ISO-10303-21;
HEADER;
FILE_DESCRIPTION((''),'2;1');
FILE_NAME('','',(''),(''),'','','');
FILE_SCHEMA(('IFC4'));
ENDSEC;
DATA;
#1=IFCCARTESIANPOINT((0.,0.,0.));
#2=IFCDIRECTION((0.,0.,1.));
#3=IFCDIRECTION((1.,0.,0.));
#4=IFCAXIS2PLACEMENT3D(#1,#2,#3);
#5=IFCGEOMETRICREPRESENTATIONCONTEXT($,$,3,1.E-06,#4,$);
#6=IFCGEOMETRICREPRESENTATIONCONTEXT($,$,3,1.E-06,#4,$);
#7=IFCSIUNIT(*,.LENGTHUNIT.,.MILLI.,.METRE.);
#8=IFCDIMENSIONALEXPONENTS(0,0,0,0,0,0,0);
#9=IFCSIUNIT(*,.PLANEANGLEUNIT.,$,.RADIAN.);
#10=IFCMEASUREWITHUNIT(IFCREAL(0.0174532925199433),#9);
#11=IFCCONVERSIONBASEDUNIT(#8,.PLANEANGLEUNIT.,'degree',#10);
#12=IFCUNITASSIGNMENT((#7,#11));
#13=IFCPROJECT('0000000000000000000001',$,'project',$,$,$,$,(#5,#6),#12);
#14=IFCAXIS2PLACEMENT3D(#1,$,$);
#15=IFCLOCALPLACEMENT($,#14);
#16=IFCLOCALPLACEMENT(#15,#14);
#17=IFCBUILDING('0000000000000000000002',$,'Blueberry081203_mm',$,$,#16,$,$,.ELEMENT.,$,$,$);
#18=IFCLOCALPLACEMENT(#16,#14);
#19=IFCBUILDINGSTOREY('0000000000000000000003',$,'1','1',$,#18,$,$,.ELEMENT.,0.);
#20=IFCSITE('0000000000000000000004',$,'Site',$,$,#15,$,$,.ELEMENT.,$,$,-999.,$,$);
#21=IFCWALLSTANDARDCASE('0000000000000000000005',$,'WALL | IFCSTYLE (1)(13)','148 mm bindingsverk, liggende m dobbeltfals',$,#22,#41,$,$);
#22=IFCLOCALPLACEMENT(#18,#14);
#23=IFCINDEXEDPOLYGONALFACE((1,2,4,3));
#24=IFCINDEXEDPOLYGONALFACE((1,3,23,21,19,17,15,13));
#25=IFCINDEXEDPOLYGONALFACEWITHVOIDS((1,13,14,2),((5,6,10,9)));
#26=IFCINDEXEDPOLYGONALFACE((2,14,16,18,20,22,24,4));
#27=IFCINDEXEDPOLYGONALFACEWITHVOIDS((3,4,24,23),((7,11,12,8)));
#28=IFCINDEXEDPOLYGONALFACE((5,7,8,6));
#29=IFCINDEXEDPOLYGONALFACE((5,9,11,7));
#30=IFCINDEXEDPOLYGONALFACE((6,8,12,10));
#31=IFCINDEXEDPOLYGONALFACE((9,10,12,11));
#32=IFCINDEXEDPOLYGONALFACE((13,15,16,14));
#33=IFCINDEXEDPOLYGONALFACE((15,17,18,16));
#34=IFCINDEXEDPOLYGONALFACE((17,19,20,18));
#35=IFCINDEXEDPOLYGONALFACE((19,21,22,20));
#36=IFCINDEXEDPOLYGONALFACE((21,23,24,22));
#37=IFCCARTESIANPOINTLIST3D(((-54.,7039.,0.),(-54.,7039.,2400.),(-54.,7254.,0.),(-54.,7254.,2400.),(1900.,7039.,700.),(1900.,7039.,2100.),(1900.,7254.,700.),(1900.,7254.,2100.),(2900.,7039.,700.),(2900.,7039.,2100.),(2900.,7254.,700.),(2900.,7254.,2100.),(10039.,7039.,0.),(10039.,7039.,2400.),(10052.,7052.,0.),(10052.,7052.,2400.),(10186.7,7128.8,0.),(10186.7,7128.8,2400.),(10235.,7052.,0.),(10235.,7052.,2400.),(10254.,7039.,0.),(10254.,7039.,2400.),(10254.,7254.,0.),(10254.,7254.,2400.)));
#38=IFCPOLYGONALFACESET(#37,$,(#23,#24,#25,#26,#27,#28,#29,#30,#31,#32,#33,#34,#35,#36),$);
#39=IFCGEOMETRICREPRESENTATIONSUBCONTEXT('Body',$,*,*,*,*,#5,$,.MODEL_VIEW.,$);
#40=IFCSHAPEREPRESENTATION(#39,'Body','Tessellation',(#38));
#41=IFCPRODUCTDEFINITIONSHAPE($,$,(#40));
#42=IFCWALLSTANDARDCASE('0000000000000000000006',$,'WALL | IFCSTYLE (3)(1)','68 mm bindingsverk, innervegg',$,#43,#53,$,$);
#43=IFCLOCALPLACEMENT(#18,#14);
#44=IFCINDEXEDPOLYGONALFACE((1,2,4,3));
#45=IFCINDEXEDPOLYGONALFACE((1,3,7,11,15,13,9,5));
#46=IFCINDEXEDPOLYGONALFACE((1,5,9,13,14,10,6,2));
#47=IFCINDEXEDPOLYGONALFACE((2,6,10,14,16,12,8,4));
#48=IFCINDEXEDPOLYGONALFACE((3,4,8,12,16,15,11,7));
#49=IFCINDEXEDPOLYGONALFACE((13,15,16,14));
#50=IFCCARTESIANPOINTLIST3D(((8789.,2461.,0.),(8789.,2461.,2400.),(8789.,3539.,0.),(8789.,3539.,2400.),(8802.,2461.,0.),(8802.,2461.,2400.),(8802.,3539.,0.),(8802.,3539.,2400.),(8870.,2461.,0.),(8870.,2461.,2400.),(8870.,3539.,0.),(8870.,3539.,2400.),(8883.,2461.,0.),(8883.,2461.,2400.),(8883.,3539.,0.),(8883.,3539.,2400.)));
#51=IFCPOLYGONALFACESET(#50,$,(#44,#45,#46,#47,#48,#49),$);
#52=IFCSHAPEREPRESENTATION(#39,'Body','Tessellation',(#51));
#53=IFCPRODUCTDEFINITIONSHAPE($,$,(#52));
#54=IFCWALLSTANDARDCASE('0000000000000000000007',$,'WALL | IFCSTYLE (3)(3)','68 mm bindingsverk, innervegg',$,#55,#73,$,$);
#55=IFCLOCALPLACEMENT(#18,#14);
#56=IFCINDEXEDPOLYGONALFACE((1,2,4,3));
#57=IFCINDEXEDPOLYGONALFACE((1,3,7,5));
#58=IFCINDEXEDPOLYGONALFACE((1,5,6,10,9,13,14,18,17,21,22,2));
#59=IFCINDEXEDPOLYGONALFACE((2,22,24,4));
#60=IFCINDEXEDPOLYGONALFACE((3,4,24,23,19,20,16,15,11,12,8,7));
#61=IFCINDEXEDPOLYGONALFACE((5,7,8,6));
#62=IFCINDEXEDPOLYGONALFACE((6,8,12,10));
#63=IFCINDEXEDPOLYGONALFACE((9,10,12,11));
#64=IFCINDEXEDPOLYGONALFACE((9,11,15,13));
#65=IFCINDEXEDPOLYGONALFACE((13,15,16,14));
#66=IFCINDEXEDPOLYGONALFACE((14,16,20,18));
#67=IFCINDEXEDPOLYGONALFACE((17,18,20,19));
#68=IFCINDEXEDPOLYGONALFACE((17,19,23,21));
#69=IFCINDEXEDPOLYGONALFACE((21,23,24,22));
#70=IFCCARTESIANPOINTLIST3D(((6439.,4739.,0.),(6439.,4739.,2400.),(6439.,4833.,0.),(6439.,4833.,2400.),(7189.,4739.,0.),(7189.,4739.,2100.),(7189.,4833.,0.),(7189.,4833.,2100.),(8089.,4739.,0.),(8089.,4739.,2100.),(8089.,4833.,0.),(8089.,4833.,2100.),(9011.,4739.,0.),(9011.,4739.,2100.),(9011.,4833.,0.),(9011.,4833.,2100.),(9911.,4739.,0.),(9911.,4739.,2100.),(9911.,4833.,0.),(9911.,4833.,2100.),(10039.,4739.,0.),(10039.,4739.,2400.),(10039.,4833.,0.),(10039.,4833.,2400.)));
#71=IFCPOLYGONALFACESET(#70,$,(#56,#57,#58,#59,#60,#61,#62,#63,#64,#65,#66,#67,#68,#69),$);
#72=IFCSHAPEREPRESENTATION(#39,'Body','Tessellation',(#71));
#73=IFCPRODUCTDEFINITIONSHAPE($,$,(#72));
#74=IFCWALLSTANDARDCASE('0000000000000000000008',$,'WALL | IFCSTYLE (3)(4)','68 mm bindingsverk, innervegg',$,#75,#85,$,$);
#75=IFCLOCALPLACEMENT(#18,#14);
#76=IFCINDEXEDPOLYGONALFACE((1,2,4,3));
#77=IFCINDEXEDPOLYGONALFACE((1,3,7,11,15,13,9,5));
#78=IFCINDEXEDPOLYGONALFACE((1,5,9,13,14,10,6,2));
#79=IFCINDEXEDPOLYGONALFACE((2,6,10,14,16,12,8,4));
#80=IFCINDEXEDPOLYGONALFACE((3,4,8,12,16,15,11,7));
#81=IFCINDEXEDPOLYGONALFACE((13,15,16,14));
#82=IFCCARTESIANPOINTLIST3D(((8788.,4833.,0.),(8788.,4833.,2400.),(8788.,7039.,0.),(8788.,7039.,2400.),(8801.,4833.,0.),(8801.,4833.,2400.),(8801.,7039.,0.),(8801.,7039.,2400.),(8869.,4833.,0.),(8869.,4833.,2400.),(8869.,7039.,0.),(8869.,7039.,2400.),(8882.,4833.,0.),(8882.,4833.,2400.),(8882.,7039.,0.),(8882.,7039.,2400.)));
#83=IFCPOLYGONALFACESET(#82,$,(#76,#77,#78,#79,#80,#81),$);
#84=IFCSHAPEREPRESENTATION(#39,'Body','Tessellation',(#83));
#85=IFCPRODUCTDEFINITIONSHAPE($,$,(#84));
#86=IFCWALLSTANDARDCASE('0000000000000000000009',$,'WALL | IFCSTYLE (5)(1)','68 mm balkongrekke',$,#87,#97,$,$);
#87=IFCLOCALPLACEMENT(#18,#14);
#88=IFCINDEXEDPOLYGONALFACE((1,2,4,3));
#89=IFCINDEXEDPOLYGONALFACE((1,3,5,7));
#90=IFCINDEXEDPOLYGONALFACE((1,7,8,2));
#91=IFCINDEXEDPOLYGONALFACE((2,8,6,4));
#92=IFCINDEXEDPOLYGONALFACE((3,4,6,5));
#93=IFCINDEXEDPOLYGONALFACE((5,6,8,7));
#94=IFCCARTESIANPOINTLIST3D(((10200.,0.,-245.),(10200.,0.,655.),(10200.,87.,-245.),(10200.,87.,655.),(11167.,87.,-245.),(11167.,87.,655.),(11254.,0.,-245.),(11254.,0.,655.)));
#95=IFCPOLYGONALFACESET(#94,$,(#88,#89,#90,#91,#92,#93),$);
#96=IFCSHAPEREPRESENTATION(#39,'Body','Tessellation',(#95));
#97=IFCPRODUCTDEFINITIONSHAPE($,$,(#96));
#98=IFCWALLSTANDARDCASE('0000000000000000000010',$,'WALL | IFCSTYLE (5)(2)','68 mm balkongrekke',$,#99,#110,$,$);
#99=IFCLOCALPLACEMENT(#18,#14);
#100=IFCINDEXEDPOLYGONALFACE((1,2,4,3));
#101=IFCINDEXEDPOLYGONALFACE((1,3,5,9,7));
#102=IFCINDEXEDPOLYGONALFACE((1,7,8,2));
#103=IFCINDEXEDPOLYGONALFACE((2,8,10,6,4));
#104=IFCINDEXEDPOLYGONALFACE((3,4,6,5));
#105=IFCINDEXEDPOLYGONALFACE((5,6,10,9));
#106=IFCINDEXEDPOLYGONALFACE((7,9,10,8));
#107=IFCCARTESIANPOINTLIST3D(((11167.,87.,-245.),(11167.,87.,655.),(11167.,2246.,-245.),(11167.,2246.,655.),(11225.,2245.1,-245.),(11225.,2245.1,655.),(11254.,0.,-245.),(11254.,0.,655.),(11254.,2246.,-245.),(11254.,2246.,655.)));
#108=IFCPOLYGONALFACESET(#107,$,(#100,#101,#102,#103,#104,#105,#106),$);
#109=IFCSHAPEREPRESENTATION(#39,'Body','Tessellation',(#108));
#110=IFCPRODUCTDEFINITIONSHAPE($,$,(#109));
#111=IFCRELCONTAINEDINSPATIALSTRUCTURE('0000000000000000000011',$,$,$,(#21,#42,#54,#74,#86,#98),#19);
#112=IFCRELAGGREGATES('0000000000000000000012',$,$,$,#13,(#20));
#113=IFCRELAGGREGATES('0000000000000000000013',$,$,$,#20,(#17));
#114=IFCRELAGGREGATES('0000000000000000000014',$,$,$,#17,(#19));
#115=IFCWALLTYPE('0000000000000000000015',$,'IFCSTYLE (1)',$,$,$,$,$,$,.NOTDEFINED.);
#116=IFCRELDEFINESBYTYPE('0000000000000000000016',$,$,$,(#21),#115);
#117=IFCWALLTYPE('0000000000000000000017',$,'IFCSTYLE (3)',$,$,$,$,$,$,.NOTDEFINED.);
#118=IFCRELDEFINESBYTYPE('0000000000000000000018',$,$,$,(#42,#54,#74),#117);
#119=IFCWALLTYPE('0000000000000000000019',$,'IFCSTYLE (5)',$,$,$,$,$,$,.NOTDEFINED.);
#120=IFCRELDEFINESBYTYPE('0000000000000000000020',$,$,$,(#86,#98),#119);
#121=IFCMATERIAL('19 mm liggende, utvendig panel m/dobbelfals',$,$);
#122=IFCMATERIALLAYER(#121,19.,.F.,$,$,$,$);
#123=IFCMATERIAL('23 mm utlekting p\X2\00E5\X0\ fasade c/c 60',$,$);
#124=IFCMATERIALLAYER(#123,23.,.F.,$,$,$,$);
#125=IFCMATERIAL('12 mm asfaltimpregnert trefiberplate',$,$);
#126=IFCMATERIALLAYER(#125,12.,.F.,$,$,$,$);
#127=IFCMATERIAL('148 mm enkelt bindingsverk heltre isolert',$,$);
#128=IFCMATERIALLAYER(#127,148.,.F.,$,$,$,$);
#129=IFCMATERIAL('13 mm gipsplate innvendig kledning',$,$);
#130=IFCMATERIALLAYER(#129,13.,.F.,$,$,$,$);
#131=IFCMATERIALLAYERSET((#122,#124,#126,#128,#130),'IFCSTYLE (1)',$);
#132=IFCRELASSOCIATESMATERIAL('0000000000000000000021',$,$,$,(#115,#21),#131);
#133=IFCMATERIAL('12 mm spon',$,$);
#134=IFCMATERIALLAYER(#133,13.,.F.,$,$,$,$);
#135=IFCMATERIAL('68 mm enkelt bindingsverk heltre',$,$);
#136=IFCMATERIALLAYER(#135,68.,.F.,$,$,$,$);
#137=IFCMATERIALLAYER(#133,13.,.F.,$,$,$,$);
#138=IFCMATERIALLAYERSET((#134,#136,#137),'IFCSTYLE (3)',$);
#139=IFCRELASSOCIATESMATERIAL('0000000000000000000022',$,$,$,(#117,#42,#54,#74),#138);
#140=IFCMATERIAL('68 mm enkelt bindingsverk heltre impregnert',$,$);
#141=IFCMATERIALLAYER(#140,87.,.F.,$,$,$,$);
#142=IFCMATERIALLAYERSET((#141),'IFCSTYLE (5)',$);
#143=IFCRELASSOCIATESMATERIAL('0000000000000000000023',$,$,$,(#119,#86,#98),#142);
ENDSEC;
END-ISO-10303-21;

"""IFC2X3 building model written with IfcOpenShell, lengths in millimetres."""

from ifc_helpers import new_model, entity, si_unit, converted_unit, frame, origin, origin_with_axes, origin_2d_with_axis, place, context, subcontext, project, spatial, polyline, segment, composite_curve, rectangle, outline, extrude, material, layer, layer_set, layer_usage, type_object, element, save


model = new_model("IFC2X3")

# Units and contexts
context_of_model_1 = context(None, 3, precision=1e-06, world=origin_with_axes())
context_of_model_2 = context(None, 3, precision=1e-06, world=origin_with_axes())
body_context = subcontext(context_of_model_1, "Body", None, "MODEL_VIEW")
ifc_project = project(units=[si_unit("LENGTHUNIT", "METRE", prefix="MILLI"), converted_unit("PLANEANGLEUNIT", "degree", entity("IfcReal", 0.0174532925199433), si_unit("PLANEANGLEUNIT", "RADIAN"), dimensions=[0, 0, 0, 0, 0, 0, 0])], contexts=[context_of_model_1, context_of_model_2])

# Site, building, storey
site_placement = place(None, origin())
site = spatial("IfcSite", under=ifc_project, at=site_placement, Name="Site", CompositionType="ELEMENT", RefElevation=-999.0)
building_placement = place(site_placement, origin())
building = spatial("IfcBuilding", under=site, at=building_placement, Name="Blueberry081203_mm", CompositionType="ELEMENT")
storey_placement = place(building_placement, origin())
storey = spatial("IfcBuildingStorey", under=building, at=storey_placement, Name="1", Description="1", CompositionType="ELEMENT", Elevation=0.0)

# Shared definitions
ifc_material_1 = material(Name="19 mm liggende, utvendig panel m/dobbelfals")
ifc_layer_1 = layer(ifc_material_1, 19.0, ventilated=False)
ifc_material_2 = material(Name="23 mm utlekting på fasade c/c 60")
ifc_layer_2 = layer(ifc_material_2, 23.0, ventilated=False)
ifc_material_3 = material(Name="12 mm asfaltimpregnert trefiberplate")
ifc_layer_3 = layer(ifc_material_3, 12.0, ventilated=False)
ifc_material_4 = material(Name="148 mm enkelt bindingsverk heltre isolert")
ifc_layer_4 = layer(ifc_material_4, 148.0, ventilated=False)
ifc_material_5 = material(Name="13 mm gipsplate innvendig kledning")
ifc_layer_5 = layer(ifc_material_5, 13.0, ventilated=False)
ifc_layer_set_1 = layer_set([ifc_layer_1, ifc_layer_2, ifc_layer_3, ifc_layer_4, ifc_layer_5], Name="IFCSTYLE (1)")
wall_type_1 = type_object("IfcWallType", Name="IFCSTYLE (1)", PredefinedType="NOTDEFINED", material=ifc_layer_set_1)

# Wall, opening
ifc_layer_usage_1 = layer_usage(ifc_layer_set_1, "AXIS2", "POSITIVE", 0.0)
wall_1_placement = place(storey_placement, frame((10254.0, 7254.0, 0.0), z_axis=(0.0, 0.0, 1.0), x_axis=(-1.0, 0.0, 0.0)))
wall_1 = element("IfcWallStandardCase", 1, at=wall_1_placement, inside=storey, type_object=wall_type_1, material=ifc_layer_usage_1, Name="WALL | IFCSTYLE (1)(13)", Description="148 mm bindingsverk, liggende m dobbeltfals", context=body_context, shape_type="SweptSolid", held_by="IfcProductRepresentation", body=[
    extrude(outline(composite_curve([segment(polyline([(0.0, 19.0), (0.0, 0.0)]), True, "CONTINUOUS"), segment(polyline([(0.0, 0.0), (0.0, 0.0)]), True, "CONTINUOUS"), segment(polyline([(0.0, 0.0), (10308.0, 0.0)]), True, "CONTINUOUS"), segment(polyline([(10308.0, 0.0), (10308.0, 19.0)]), True, "CONTINUOUS"), segment(polyline([(10308.0, 19.0), (10308.0, 42.0)]), True, "CONTINUOUS"), segment(polyline([(10308.0, 42.0), (10308.0, 54.0)]), True, "CONTINUOUS"), segment(polyline([(10308.0, 54.0), (10308.0, 202.0)]), True, "CONTINUOUS"), segment(polyline([(10308.0, 202.0), (10308.0, 215.0)]), True, "CONTINUOUS"), segment(polyline([(10308.0, 215.0), (215.0, 215.0)]), True, "CONTINUOUS"), segment(polyline([(215.0, 215.0), (202.0, 202.0)]), True, "CONTINUOUS"), segment(polyline([(202.0, 202.0), (67.3, 125.2)]), True, "CONTINUOUS"), segment(polyline([(67.3, 125.2), (19.0, 202.0)]), True, "CONTINUOUS"), segment(polyline([(19.0, 202.0), (0.0, 215.0)]), True, "CONTINUOUS"), segment(polyline([(0.0, 215.0), (0.0, 215.0)]), True, "CONTINUOUS"), segment(polyline([(0.0, 215.0), (0.0, 202.0)]), True, "CONTINUOUS"), segment(polyline([(0.0, 202.0), (0.0, 54.0)]), True, "CONTINUOUS"), segment(polyline([(0.0, 54.0), (0.0, 42.0)]), True, "CONTINUOUS"), segment(polyline([(0.0, 42.0), (0.0, 19.0)]), True, "CONTINUOUS")], self_intersect=False)), origin(), (0.0, 0.0, 1.0), 2400.0),
])
opening_1_placement = place(wall_1_placement, frame((7354.0, 107.5, 700.0)))
element("IfcOpeningElement", 2, at=opening_1_placement, cuts=wall_1, context=body_context, shape_type="SweptSolid", held_by="IfcProductRepresentation", body=[
    extrude(rectangle(XDim=1000.0, YDim=1400.0, at=origin_2d_with_axis()), frame((500.0, 107.5, 700.0), z_axis=(0.0, -1.0, 0.0), x_axis=(1.0, 0.0, 0.0)), (0.0, 0.0, 1.0), 215.0),
])

# Wall
ifc_material_6 = material(Name="12 mm spon")
ifc_layer_6 = layer(ifc_material_6, 13.0, ventilated=False)
ifc_material_7 = material(Name="68 mm enkelt bindingsverk heltre")
ifc_layer_7 = layer(ifc_material_7, 68.0, ventilated=False)
ifc_layer_8 = layer(ifc_material_6, 13.0, ventilated=False)
ifc_layer_set_2 = layer_set([ifc_layer_6, ifc_layer_7, ifc_layer_8], Name="IFCSTYLE (3)")
ifc_layer_usage_2 = layer_usage(ifc_layer_set_2, "AXIS2", "POSITIVE", 0.0)
wall_type_2 = type_object("IfcWallType", Name="IFCSTYLE (3)", PredefinedType="NOTDEFINED", material=ifc_layer_set_2)
wall_2_placement = place(storey_placement, frame((8883.0, 2461.0, 0.0), z_axis=(0.0, 0.0, 1.0), x_axis=(0.0, 1.0, 0.0)))
element("IfcWallStandardCase", 3, at=wall_2_placement, inside=storey, type_object=wall_type_2, material=ifc_layer_usage_2, Name="WALL | IFCSTYLE (3)(1)", Description="68 mm bindingsverk, innervegg", context=body_context, shape_type="SweptSolid", held_by="IfcProductRepresentation", body=[
    extrude(outline(composite_curve([segment(polyline([(0.0, 13.0), (0.0, 0.0)]), True, "CONTINUOUS"), segment(polyline([(0.0, 0.0), (1078.0, 0.0)]), True, "CONTINUOUS"), segment(polyline([(1078.0, 0.0), (1078.0, 13.0)]), True, "CONTINUOUS"), segment(polyline([(1078.0, 13.0), (1078.0, 81.0)]), True, "CONTINUOUS"), segment(polyline([(1078.0, 81.0), (1078.0, 94.0)]), True, "CONTINUOUS"), segment(polyline([(1078.0, 94.0), (0.0, 94.0)]), True, "CONTINUOUS"), segment(polyline([(0.0, 94.0), (0.0, 81.0)]), True, "CONTINUOUS"), segment(polyline([(0.0, 81.0), (0.0, 13.0)]), True, "CONTINUOUS")], self_intersect=False)), origin(), (0.0, 0.0, 1.0), 2400.0),
])

# Wall, openings
ifc_layer_usage_3 = layer_usage(ifc_layer_set_2, "AXIS2", "POSITIVE", 0.0)
wall_3_placement = place(storey_placement, frame((6439.0, 4739.0, 0.0)))
wall_3 = element("IfcWallStandardCase", 4, at=wall_3_placement, inside=storey, type_object=wall_type_2, material=ifc_layer_usage_3, Name="WALL | IFCSTYLE (3)(3)", Description="68 mm bindingsverk, innervegg", context=body_context, shape_type="SweptSolid", held_by="IfcProductRepresentation", body=[
    extrude(outline(composite_curve([segment(polyline([(0.0, 13.0), (0.0, 0.0)]), True, "CONTINUOUS"), segment(polyline([(0.0, 0.0), (3600.0, 0.0)]), True, "CONTINUOUS"), segment(polyline([(3600.0, 0.0), (3600.0, 13.0)]), True, "CONTINUOUS"), segment(polyline([(3600.0, 13.0), (3600.0, 81.0)]), True, "CONTINUOUS"), segment(polyline([(3600.0, 81.0), (3600.0, 94.0)]), True, "CONTINUOUS"), segment(polyline([(3600.0, 94.0), (0.0, 94.0)]), True, "CONTINUOUS"), segment(polyline([(0.0, 94.0), (0.0, 81.0)]), True, "CONTINUOUS"), segment(polyline([(0.0, 81.0), (0.0, 13.0)]), True, "CONTINUOUS")], self_intersect=False)), origin(), (0.0, 0.0, 1.0), 2400.0),
])
opening_2_placement = place(wall_3_placement, frame((2572.0, 47.0, 0.0)))
element("IfcOpeningElement", 5, at=opening_2_placement, cuts=wall_3, context=body_context, shape_type="SweptSolid", held_by="IfcProductRepresentation", body=[
    extrude(rectangle(XDim=900.0, YDim=2100.0, at=origin_2d_with_axis()), frame((450.0, 47.0, 1050.0), z_axis=(0.0, -1.0, 0.0), x_axis=(1.0, 0.0, 0.0)), (0.0, 0.0, 1.0), 94.0),
])
opening_3_placement = place(wall_3_placement, frame((750.0, 47.0, 0.0)))
element("IfcOpeningElement", 6, at=opening_3_placement, cuts=wall_3, context=body_context, shape_type="SweptSolid", held_by="IfcProductRepresentation", body=[
    extrude(rectangle(XDim=900.0, YDim=2100.0, at=origin_2d_with_axis()), frame((450.0, 47.0, 1050.0), z_axis=(0.0, -1.0, 0.0), x_axis=(1.0, 0.0, 0.0)), (0.0, 0.0, 1.0), 94.0),
])

# Walls
ifc_layer_usage_4 = layer_usage(ifc_layer_set_2, "AXIS2", "POSITIVE", 0.0)
wall_4_placement = place(storey_placement, frame((8882.0, 4833.0, 0.0), z_axis=(0.0, 0.0, 1.0), x_axis=(0.0, 1.0, 0.0)))
element("IfcWallStandardCase", 7, at=wall_4_placement, inside=storey, type_object=wall_type_2, material=ifc_layer_usage_4, Name="WALL | IFCSTYLE (3)(4)", Description="68 mm bindingsverk, innervegg", context=body_context, shape_type="SweptSolid", held_by="IfcProductRepresentation", body=[
    extrude(outline(composite_curve([segment(polyline([(0.0, 13.0), (0.0, 0.0)]), True, "CONTINUOUS"), segment(polyline([(0.0, 0.0), (2206.0, 0.0)]), True, "CONTINUOUS"), segment(polyline([(2206.0, 0.0), (2206.0, 13.0)]), True, "CONTINUOUS"), segment(polyline([(2206.0, 13.0), (2206.0, 81.0)]), True, "CONTINUOUS"), segment(polyline([(2206.0, 81.0), (2206.0, 94.0)]), True, "CONTINUOUS"), segment(polyline([(2206.0, 94.0), (0.0, 94.0)]), True, "CONTINUOUS"), segment(polyline([(0.0, 94.0), (0.0, 81.0)]), True, "CONTINUOUS"), segment(polyline([(0.0, 81.0), (0.0, 13.0)]), True, "CONTINUOUS")], self_intersect=False)), origin(), (0.0, 0.0, 1.0), 2400.0),
])
ifc_material_8 = material(Name="68 mm enkelt bindingsverk heltre impregnert")
ifc_layer_9 = layer(ifc_material_8, 87.0, ventilated=False)
ifc_layer_set_3 = layer_set([ifc_layer_9], Name="IFCSTYLE (5)")
ifc_layer_usage_5 = layer_usage(ifc_layer_set_3, "AXIS2", "POSITIVE", 0.0)
wall_type_3 = type_object("IfcWallType", Name="IFCSTYLE (5)", PredefinedType="NOTDEFINED", material=ifc_layer_set_3)
wall_5_placement = place(storey_placement, frame((10200.0, 0.0, -245.0)))
element("IfcWallStandardCase", 8, at=wall_5_placement, inside=storey, type_object=wall_type_3, material=ifc_layer_usage_5, Name="WALL | IFCSTYLE (5)(1)", Description="68 mm balkongrekke", context=body_context, shape_type="SweptSolid", held_by="IfcProductRepresentation", body=[
    extrude(outline(composite_curve([segment(polyline([(0.0, 87.0), (0.0, 0.0)]), True, "CONTINUOUS"), segment(polyline([(0.0, 0.0), (1054.0, 0.0)]), True, "CONTINUOUS"), segment(polyline([(1054.0, 0.0), (967.0, 87.0)]), True, "CONTINUOUS"), segment(polyline([(967.0, 87.0), (0.0, 87.0)]), True, "CONTINUOUS")], self_intersect=False)), origin(), (0.0, 0.0, 1.0), 900.0),
])
ifc_layer_usage_6 = layer_usage(ifc_layer_set_3, "AXIS2", "POSITIVE", 0.0)
wall_6_placement = place(storey_placement, frame((11254.0, 0.0, -245.0), z_axis=(0.0, 0.0, 1.0), x_axis=(0.0, 1.0, 0.0)))
element("IfcWallStandardCase", 9, at=wall_6_placement, inside=storey, type_object=wall_type_3, material=ifc_layer_usage_6, Name="WALL | IFCSTYLE (5)(2)", Description="68 mm balkongrekke", context=body_context, shape_type="SweptSolid", held_by="IfcProductRepresentation", body=[
    extrude(outline(composite_curve([segment(polyline([(87.0, 87.0), (0.0, 0.0)]), True, "CONTINUOUS"), segment(polyline([(0.0, 0.0), (2246.0, 0.0)]), True, "CONTINUOUS"), segment(polyline([(2246.0, 0.0), (2245.1, 29.0)]), True, "CONTINUOUS"), segment(polyline([(2245.1, 29.0), (2246.0, 87.0)]), True, "CONTINUOUS"), segment(polyline([(2246.0, 87.0), (87.0, 87.0)]), True, "CONTINUOUS")], self_intersect=False)), origin(), (0.0, 0.0, 1.0), 900.0),
])

save(model, "model.ifc")
